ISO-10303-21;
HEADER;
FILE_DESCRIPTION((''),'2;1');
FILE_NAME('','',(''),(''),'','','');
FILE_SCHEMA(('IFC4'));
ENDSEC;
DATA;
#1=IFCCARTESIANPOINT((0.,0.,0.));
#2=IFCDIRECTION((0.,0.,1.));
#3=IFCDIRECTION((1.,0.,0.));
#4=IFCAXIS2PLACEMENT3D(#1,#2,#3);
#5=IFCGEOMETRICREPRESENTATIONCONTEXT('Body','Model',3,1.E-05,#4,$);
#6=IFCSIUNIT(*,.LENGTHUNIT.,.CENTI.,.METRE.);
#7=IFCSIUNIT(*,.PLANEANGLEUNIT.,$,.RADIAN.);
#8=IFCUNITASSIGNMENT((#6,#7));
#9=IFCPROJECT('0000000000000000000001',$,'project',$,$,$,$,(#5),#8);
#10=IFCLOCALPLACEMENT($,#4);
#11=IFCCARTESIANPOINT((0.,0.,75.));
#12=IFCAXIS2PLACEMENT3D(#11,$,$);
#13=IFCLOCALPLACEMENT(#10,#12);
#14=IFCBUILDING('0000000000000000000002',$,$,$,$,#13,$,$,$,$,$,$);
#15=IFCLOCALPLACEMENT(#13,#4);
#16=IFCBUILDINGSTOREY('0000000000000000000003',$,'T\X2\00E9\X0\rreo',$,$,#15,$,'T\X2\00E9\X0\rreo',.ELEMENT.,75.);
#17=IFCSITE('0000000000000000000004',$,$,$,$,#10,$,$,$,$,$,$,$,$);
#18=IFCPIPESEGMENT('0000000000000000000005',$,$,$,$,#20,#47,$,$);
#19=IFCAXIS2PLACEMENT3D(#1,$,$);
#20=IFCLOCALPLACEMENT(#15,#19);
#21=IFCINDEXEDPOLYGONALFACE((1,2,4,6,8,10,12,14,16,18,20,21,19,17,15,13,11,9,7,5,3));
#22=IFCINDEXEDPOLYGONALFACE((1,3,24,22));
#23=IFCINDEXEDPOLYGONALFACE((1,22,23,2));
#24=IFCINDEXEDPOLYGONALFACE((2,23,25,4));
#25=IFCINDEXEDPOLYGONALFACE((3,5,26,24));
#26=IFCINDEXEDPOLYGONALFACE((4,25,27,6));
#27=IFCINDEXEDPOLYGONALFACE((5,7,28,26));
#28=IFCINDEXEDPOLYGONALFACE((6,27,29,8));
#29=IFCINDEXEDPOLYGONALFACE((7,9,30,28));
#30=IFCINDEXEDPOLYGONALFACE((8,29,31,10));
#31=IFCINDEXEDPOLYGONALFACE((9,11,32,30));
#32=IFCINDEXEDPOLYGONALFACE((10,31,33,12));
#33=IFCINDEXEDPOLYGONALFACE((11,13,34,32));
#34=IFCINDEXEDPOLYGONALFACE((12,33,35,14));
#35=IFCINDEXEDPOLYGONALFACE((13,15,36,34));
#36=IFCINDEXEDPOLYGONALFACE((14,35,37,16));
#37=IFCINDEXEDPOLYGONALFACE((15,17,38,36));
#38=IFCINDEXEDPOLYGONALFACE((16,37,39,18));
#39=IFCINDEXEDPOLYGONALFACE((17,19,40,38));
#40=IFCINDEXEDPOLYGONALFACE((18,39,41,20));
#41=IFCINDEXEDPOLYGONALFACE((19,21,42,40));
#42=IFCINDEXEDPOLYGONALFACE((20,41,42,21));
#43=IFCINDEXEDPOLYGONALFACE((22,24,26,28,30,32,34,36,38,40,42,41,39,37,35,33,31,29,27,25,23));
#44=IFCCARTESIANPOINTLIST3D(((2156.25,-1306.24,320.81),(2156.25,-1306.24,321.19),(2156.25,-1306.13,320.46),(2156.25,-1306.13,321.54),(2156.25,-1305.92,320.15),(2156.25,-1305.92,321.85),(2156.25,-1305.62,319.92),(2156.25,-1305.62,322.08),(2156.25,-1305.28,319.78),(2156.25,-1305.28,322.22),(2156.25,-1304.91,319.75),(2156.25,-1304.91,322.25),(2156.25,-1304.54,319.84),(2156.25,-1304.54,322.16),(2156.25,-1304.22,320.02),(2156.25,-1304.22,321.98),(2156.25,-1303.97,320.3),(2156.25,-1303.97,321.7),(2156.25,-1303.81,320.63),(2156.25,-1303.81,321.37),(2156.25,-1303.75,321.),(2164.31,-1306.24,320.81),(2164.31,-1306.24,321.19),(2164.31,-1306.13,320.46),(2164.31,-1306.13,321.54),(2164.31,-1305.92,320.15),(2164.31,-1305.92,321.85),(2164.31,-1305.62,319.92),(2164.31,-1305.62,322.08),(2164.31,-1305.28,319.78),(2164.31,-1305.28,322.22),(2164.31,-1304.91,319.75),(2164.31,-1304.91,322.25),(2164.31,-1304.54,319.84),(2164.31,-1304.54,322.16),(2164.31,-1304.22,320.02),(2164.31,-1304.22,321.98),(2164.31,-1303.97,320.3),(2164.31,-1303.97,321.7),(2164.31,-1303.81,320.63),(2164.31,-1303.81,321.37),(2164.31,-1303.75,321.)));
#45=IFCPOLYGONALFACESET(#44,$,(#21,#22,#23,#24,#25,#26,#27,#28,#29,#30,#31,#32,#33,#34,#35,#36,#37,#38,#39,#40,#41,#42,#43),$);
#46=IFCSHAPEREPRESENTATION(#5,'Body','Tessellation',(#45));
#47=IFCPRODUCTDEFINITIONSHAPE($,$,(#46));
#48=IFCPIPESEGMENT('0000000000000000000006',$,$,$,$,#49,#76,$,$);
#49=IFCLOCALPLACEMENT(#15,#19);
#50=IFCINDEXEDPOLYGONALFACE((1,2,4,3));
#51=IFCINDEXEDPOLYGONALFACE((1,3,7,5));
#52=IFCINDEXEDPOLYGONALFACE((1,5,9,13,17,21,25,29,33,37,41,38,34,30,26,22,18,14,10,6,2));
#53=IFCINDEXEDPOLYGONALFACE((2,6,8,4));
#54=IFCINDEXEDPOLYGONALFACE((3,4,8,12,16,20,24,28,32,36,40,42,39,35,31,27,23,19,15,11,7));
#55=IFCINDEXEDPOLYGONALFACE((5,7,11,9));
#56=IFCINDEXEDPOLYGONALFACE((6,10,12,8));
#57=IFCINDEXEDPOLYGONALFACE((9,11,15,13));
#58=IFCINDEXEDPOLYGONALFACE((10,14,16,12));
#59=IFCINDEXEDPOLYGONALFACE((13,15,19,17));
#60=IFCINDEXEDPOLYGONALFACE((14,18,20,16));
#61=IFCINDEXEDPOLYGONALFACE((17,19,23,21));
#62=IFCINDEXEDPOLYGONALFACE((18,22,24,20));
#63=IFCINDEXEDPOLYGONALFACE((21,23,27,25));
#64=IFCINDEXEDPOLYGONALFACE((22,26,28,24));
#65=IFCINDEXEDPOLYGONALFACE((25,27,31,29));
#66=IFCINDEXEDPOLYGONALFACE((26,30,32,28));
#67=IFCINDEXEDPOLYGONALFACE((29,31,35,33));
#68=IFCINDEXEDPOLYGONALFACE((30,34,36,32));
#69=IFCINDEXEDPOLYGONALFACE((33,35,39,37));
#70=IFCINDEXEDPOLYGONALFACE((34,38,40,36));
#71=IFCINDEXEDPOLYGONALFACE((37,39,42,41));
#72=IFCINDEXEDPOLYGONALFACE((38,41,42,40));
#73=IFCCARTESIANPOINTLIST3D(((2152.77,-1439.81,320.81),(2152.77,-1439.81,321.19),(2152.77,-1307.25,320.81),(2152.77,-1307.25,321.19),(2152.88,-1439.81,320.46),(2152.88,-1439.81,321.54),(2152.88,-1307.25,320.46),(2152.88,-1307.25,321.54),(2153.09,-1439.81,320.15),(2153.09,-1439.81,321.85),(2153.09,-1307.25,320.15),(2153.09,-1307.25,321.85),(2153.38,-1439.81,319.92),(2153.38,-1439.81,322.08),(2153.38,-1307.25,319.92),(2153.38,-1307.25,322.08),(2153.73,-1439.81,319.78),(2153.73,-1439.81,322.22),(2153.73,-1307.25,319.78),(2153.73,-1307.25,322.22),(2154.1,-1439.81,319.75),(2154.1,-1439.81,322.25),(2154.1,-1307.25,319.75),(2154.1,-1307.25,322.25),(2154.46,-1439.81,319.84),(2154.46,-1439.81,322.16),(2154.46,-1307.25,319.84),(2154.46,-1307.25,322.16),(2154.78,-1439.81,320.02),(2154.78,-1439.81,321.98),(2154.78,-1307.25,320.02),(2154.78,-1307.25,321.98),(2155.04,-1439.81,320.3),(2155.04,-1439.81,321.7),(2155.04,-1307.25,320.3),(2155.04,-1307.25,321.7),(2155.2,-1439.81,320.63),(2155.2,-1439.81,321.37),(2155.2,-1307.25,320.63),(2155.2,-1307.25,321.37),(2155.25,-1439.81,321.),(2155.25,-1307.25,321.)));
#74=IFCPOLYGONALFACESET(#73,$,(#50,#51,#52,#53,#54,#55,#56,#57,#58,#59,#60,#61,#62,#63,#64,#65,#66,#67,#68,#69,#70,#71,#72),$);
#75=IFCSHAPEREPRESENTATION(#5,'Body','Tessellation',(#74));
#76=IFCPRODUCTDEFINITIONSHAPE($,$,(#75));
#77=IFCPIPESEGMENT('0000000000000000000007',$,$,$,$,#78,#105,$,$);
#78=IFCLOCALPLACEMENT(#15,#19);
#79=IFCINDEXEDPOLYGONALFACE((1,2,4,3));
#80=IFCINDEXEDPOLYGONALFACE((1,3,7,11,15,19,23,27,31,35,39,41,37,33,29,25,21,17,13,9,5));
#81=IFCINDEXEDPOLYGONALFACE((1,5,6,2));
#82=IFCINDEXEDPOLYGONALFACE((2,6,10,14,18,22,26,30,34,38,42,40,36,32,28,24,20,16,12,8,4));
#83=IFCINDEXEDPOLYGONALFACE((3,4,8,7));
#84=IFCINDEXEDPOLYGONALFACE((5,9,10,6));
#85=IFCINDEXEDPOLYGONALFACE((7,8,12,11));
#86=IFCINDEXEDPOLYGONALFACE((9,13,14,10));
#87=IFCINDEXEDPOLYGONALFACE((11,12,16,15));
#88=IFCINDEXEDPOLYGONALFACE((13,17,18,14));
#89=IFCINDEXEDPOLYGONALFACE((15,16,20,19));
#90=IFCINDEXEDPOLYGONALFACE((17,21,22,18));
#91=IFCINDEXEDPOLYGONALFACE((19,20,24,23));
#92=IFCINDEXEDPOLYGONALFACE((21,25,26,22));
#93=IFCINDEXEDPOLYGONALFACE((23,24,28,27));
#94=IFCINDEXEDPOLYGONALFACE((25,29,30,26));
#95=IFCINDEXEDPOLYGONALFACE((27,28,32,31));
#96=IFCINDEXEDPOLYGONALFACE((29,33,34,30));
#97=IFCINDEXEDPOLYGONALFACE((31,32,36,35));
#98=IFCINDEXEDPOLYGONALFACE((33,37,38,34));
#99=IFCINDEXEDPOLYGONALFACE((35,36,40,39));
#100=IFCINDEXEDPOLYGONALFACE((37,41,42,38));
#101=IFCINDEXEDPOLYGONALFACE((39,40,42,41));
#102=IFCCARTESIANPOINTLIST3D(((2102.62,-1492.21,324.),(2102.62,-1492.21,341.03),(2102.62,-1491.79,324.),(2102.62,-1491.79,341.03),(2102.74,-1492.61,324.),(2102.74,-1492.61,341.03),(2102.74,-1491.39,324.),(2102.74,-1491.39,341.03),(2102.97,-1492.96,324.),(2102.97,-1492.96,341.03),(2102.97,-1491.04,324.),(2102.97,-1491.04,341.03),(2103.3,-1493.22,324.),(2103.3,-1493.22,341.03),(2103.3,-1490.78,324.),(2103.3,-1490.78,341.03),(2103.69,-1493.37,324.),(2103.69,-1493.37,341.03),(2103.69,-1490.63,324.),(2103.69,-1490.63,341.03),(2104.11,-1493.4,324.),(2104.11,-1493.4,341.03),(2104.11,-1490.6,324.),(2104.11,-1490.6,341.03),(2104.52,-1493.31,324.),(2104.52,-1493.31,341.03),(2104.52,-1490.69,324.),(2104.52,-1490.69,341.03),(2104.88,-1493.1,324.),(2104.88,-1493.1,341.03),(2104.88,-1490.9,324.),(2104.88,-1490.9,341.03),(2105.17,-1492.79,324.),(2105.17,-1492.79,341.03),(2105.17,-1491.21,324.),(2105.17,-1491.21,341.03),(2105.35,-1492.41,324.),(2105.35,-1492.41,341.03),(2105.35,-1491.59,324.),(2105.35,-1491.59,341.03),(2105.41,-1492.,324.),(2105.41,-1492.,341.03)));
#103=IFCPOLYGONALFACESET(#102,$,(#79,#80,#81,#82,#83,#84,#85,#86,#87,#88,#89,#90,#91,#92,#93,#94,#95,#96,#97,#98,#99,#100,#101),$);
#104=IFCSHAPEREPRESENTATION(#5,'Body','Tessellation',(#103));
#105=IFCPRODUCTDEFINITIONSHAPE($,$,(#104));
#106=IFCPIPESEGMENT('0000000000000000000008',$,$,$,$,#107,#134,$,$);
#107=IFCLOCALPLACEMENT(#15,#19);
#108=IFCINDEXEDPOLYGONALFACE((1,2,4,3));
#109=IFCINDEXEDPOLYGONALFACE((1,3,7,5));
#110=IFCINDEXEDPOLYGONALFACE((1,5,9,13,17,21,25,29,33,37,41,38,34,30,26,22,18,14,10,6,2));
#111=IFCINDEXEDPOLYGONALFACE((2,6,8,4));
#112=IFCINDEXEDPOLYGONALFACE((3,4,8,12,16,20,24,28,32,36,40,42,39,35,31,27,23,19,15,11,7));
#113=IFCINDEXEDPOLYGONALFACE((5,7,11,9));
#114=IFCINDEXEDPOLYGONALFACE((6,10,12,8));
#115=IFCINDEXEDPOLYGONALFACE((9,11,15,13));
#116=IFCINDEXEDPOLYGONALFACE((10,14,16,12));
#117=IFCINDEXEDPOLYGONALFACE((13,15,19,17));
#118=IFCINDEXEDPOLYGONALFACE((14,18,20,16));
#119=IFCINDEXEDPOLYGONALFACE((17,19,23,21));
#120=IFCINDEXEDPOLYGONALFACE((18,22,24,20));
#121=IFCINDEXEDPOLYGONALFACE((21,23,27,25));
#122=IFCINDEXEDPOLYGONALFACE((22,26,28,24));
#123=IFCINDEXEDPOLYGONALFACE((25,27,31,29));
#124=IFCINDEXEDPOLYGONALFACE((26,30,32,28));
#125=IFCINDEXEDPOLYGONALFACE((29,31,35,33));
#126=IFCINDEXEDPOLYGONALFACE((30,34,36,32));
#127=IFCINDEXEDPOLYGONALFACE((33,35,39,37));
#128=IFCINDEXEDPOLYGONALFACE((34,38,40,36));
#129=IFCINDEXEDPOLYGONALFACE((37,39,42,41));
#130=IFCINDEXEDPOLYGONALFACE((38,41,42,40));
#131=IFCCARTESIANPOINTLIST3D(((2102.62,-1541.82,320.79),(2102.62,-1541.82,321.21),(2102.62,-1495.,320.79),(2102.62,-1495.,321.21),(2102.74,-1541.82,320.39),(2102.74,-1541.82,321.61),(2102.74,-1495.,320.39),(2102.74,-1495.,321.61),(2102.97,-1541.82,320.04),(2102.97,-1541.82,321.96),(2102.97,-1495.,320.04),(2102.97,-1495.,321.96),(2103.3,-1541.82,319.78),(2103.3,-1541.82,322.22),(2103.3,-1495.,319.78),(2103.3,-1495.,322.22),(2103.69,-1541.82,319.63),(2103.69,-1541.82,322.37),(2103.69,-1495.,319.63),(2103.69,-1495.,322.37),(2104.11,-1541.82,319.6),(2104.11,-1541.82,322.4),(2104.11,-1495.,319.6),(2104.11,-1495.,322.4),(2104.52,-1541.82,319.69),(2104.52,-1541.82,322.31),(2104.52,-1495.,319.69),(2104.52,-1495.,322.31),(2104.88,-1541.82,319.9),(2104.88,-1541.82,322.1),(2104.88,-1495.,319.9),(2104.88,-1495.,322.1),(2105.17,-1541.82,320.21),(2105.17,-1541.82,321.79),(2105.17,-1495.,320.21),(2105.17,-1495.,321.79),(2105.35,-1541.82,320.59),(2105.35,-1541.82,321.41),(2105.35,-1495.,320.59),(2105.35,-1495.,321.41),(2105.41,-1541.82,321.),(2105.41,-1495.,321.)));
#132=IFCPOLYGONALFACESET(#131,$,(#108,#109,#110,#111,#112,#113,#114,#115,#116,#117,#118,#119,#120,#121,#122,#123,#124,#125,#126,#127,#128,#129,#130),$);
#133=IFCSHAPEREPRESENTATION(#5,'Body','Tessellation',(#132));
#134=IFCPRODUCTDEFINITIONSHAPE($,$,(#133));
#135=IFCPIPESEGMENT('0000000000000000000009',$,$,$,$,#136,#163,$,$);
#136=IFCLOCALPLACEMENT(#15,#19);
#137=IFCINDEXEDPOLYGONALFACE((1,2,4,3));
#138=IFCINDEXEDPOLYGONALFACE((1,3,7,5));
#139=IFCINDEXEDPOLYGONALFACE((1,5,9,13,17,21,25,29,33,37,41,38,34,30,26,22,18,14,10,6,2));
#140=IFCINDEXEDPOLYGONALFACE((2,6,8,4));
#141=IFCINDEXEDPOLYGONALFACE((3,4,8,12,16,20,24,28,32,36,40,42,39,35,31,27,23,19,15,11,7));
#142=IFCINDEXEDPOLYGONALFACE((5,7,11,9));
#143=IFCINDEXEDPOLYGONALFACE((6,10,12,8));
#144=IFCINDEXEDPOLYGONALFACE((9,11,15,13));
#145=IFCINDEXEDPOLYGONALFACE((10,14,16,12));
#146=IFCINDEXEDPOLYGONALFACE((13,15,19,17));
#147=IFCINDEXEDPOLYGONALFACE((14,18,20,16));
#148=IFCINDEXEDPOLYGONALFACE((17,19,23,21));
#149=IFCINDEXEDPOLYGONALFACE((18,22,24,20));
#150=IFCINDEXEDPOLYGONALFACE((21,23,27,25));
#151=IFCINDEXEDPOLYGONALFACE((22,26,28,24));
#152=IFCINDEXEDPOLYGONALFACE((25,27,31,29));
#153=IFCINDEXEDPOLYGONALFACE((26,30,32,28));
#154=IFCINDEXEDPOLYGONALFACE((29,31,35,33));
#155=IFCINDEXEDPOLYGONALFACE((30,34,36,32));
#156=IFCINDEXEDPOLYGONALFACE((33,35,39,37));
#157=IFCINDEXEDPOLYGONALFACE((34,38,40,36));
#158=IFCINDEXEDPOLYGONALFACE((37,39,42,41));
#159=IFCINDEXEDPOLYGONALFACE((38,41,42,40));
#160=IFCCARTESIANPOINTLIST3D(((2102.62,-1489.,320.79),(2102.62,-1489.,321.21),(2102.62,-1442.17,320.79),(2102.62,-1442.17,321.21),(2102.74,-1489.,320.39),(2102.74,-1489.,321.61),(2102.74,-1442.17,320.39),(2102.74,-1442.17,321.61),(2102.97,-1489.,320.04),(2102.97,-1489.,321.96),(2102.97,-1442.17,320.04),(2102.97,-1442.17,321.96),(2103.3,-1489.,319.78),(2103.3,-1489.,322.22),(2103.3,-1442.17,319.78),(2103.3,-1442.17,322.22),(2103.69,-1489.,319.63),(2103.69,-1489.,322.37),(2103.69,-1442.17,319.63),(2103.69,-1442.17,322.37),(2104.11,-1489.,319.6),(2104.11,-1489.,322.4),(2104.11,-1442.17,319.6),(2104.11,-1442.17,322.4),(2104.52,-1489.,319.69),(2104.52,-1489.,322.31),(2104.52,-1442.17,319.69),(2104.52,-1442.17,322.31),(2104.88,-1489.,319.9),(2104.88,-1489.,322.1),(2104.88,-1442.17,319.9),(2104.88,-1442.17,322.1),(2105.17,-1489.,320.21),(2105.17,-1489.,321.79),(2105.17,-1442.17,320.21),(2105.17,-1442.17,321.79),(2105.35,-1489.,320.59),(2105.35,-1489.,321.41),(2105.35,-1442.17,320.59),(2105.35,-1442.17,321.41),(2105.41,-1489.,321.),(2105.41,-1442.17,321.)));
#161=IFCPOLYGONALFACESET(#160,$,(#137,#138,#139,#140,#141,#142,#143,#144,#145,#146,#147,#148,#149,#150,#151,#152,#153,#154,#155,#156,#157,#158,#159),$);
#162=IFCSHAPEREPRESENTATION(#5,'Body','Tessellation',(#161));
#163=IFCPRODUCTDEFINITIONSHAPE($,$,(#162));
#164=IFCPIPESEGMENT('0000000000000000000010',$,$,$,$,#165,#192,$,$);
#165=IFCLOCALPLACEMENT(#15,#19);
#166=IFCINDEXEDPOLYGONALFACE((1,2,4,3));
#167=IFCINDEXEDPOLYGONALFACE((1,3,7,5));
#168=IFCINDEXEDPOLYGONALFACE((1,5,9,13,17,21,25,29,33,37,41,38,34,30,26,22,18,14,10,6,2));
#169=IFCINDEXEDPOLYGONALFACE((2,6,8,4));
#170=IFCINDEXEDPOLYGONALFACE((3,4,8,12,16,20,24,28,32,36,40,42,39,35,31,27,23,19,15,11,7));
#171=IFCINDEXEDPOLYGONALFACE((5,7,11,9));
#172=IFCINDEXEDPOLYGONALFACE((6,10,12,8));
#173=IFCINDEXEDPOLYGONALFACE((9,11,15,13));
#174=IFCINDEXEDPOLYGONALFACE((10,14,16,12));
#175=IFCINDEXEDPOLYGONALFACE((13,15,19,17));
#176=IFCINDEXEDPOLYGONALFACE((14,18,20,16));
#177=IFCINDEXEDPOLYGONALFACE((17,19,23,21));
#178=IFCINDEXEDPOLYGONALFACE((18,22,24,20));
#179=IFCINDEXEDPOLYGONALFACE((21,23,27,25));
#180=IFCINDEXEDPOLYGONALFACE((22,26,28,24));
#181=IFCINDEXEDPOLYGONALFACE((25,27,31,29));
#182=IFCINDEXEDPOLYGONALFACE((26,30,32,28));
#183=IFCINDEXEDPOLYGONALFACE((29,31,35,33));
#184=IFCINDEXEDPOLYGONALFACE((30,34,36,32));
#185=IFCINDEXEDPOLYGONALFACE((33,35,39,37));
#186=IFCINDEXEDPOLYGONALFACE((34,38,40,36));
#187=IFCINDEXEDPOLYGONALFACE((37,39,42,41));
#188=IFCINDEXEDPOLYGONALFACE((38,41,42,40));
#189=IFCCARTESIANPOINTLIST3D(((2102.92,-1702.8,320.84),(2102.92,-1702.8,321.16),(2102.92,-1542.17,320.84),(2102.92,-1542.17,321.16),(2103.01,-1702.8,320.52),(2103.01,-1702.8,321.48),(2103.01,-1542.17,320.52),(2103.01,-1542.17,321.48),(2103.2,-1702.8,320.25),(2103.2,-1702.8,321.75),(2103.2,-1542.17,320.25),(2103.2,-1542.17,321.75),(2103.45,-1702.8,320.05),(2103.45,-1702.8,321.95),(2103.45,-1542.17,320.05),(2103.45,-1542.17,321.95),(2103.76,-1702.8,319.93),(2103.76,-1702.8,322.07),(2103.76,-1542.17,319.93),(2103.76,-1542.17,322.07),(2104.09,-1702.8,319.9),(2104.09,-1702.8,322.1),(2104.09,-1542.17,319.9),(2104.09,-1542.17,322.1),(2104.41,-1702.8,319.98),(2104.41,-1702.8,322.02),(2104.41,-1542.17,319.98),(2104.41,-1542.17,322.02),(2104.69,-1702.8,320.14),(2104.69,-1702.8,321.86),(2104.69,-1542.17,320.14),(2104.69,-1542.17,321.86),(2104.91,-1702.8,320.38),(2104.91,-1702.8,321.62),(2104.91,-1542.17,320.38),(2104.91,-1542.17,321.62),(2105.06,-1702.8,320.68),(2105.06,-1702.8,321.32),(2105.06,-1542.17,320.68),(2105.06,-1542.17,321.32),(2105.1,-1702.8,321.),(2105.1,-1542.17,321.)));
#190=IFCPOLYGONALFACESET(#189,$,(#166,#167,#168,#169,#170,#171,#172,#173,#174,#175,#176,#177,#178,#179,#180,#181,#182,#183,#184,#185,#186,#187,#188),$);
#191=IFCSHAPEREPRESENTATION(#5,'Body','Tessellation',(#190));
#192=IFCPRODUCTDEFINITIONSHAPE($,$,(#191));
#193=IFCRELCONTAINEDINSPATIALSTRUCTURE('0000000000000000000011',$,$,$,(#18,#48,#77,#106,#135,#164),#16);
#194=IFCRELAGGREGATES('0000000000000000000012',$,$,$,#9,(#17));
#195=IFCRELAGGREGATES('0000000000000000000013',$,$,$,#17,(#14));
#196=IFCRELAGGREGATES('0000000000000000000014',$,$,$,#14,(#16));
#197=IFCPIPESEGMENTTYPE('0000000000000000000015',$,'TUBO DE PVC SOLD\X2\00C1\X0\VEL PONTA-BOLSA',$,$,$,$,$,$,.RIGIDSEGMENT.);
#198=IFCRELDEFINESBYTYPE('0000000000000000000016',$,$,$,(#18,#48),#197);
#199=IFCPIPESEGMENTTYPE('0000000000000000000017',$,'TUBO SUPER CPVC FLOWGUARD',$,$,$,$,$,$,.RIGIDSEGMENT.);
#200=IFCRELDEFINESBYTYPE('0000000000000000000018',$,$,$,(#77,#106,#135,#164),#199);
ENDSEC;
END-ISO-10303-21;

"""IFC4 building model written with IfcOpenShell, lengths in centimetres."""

from ifc_helpers import new_model, si_unit, frame, origin_with_axes, origin_2d_with_axis, place, context, project, spatial, circle, extrude, type_object, element, save


model = new_model("IFC4")

# Units and contexts
model_context = context("Model", 3, precision=1e-05, world=origin_with_axes(), identifier="Body")
ifc_project = project(units=[si_unit("LENGTHUNIT", "METRE", prefix="CENTI"), si_unit("PLANEANGLEUNIT", "RADIAN")], contexts=[model_context])

# Site, building, storey
site_placement = place(None, origin_with_axes())
site = spatial("IfcSite", under=ifc_project, at=site_placement)
building_placement = place(site_placement, frame((0.0, 0.0, 75.0)))
building = spatial("IfcBuilding", under=site, at=building_placement)
storey_placement = place(building_placement, origin_with_axes())
storey = spatial("IfcBuildingStorey", under=building, at=storey_placement, Name="Térreo", LongName="Térreo", CompositionType="ELEMENT", Elevation=75.0)

# Pipe segments
pipe_segment_type_1 = type_object("IfcPipeSegmentType", Name="TUBO DE PVC SOLDÁVEL PONTA-BOLSA", PredefinedType="RIGIDSEGMENT")
pipe_segment_1_placement = place(storey_placement, frame((2160.28, -1305.0, 322.25), z_axis=(0.0, 0.0, 1.0), x_axis=(1.0, 0.0, 0.0)))
element("IfcPipeSegment", 1, at=pipe_segment_1_placement, inside=storey, type_object=pipe_segment_type_1, context=model_context, shape_type="SolidModel", body=[
    extrude(circle(Radius=1.25, at=origin_2d_with_axis()), frame((-4.03, 0.0, -1.25), z_axis=(1.0, 0.0, 0.0), x_axis=(0.0, 1.0, 0.0)), (0.0, 0.0, 1.0), 8.05),
])
pipe_segment_2_placement = place(storey_placement, frame((2154.0, -1373.53, 322.25), z_axis=(0.0, 0.0, 1.0), x_axis=(1.0, 0.0, 0.0)))
element("IfcPipeSegment", 2, at=pipe_segment_2_placement, inside=storey, type_object=pipe_segment_type_1, context=model_context, shape_type="SolidModel", body=[
    extrude(circle(Radius=1.25, at=origin_2d_with_axis()), frame((0.0, -66.28, -1.25), z_axis=(0.0, 1.0, 0.0), x_axis=(1.0, 0.0, 0.0)), (0.0, 0.0, 1.0), 132.56),
])
pipe_segment_type_2 = type_object("IfcPipeSegmentType", Name="TUBO SUPER CPVC FLOWGUARD", PredefinedType="RIGIDSEGMENT")
pipe_segment_3_placement = place(storey_placement, frame((2104.0, -1492.0, 341.03), z_axis=(0.0, 0.0, 1.0), x_axis=(1.0, 0.0, 0.0)))
element("IfcPipeSegment", 3, at=pipe_segment_3_placement, inside=storey, type_object=pipe_segment_type_2, context=model_context, shape_type="SolidModel", body=[
    extrude(circle(Radius=1.41, at=origin_2d_with_axis()), frame((0.0, 0.0, 0.0), z_axis=(0.0, 0.0, -1.0), x_axis=(1.0, 0.0, 0.0)), (0.0, 0.0, 1.0), 17.03),
])
pipe_segment_4_placement = place(storey_placement, frame((2104.0, -1518.41, 322.4), z_axis=(0.0, 0.0, 1.0), x_axis=(1.0, 0.0, 0.0)))
element("IfcPipeSegment", 4, at=pipe_segment_4_placement, inside=storey, type_object=pipe_segment_type_2, context=model_context, shape_type="SolidModel", body=[
    extrude(circle(Radius=1.41, at=origin_2d_with_axis()), frame((0.0, 23.41, -1.41), z_axis=(0.0, -1.0, 0.0), x_axis=(1.0, 0.0, 0.0)), (0.0, 0.0, 1.0), 46.83),
])
pipe_segment_5_placement = place(storey_placement, frame((2104.0, -1465.59, 322.4), z_axis=(0.0, 0.0, 1.0), x_axis=(1.0, 0.0, 0.0)))
element("IfcPipeSegment", 5, at=pipe_segment_5_placement, inside=storey, type_object=pipe_segment_type_2, context=model_context, shape_type="SolidModel", body=[
    extrude(circle(Radius=1.41, at=origin_2d_with_axis()), frame((0.0, -23.41, -1.41), z_axis=(0.0, 1.0, 0.0), x_axis=(1.0, 0.0, 0.0)), (0.0, 0.0, 1.0), 46.82),
])
pipe_segment_6_placement = place(storey_placement, frame((2104.0, -1622.49, 322.1), z_axis=(0.0, 0.0, 1.0), x_axis=(1.0, 0.0, 0.0)))
element("IfcPipeSegment", 6, at=pipe_segment_6_placement, inside=storey, type_object=pipe_segment_type_2, context=model_context, shape_type="SolidModel", body=[
    extrude(circle(Radius=1.1, at=origin_2d_with_axis()), frame((0.0, 80.31, -1.1), z_axis=(0.0, -1.0, 0.0), x_axis=(1.0, 0.0, 0.0)), (0.0, 0.0, 1.0), 160.62),
])

save(model, "model.ifc")
